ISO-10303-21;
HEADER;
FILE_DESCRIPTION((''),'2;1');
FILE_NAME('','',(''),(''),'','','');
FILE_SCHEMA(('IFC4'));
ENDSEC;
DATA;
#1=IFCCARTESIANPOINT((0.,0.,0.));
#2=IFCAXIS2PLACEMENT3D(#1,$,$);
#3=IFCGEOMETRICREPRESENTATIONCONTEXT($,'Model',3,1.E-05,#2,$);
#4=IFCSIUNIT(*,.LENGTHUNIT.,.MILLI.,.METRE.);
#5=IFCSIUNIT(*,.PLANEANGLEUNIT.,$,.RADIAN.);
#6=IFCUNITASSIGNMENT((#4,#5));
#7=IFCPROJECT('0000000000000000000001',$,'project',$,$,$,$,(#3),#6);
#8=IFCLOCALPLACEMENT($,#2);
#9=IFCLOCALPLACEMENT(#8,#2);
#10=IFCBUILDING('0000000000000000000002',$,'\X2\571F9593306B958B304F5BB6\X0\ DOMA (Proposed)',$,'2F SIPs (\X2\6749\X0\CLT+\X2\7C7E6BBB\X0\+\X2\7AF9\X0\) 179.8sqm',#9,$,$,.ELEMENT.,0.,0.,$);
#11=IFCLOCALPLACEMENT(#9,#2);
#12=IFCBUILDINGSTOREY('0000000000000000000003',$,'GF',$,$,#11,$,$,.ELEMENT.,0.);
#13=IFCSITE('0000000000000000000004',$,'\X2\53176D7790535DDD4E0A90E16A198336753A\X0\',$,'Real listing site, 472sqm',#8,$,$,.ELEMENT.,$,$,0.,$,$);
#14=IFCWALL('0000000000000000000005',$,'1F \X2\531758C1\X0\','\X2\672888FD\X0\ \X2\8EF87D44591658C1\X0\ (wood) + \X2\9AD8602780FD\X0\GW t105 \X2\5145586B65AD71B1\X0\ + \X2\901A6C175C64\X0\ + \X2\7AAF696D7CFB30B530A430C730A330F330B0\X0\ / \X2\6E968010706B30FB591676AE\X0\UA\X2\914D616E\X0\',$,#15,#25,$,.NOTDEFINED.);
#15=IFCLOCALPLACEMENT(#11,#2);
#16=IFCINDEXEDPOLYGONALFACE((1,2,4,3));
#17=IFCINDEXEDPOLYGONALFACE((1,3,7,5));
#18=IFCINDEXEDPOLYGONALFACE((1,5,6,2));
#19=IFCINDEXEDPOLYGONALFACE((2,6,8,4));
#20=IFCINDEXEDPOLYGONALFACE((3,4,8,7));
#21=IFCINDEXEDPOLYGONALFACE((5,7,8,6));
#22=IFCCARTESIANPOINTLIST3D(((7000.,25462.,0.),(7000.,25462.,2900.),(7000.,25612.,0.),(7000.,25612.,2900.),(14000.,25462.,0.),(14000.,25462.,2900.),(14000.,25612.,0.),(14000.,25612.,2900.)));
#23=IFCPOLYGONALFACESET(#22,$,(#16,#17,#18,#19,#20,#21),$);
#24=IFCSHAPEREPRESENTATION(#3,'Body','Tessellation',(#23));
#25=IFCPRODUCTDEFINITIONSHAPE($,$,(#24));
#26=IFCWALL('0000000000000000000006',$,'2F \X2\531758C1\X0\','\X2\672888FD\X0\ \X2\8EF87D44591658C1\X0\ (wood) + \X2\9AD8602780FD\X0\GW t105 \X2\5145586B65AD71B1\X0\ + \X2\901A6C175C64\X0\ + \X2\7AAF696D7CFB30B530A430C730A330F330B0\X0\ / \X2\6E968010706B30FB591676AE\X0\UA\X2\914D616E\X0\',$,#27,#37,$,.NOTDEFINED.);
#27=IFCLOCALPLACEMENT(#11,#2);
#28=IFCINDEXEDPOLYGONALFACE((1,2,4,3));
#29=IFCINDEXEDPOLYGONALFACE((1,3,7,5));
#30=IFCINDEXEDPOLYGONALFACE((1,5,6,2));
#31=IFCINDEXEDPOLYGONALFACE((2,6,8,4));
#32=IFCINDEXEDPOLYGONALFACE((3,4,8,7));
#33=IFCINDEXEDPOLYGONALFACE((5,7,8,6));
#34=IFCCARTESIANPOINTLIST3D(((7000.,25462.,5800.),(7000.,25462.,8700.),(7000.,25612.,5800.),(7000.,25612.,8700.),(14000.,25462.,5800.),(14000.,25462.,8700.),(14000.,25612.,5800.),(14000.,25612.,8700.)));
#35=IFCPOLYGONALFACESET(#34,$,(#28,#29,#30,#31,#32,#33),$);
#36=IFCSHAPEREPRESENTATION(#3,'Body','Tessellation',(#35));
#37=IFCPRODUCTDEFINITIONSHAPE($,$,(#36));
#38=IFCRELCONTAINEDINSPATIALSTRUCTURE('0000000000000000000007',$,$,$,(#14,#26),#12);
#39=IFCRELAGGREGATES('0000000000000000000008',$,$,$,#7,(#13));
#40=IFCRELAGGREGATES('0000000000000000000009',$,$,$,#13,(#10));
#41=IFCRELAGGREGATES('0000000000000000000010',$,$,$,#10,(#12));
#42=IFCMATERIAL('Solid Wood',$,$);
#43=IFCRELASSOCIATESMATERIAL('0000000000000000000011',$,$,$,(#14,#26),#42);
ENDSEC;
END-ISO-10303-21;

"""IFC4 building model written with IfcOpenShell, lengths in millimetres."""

from ifc_helpers import new_model, si_unit, frame, frame_2d, origin, place, context, project, spatial, rectangle, extrude, material, element, save


model = new_model("IFC4")

# Units and contexts
model_context = context("Model", 3, precision=1e-05, world=origin())
ifc_project = project(units=[si_unit("LENGTHUNIT", "METRE", prefix="MILLI"), si_unit("PLANEANGLEUNIT", "RADIAN")], contexts=[model_context])

# Site, building, storey
site_placement = place(None, origin())
site = spatial("IfcSite", under=ifc_project, at=site_placement, Name="北海道川上郡標茶町", ObjectType="Real listing site, 472sqm", CompositionType="ELEMENT", RefElevation=0.0)
building_placement = place(site_placement, origin())
building = spatial("IfcBuilding", under=site, at=building_placement, Name="土間に開く家 DOMA (Proposed)", ObjectType="2F SIPs (杉CLT+籾殻+竹) 179.8sqm", CompositionType="ELEMENT", ElevationOfRefHeight=0.0, ElevationOfTerrain=0.0)
storey_placement = place(building_placement, origin())
storey = spatial("IfcBuildingStorey", under=building, at=storey_placement, Name="GF", CompositionType="ELEMENT", Elevation=0.0)

# Shared definitions
ifc_material_1 = material(Name="Solid Wood")

# Wall
wall_1_placement = place(storey_placement, frame((3500.0, 12731.0, 0.0)))
element("IfcWall", 1, at=wall_1_placement, inside=storey, material=ifc_material_1, Name="1F 北壁", Description="木製 軸組外壁 (wood) + 高性能GW t105 充填断熱 + 通気層 + 窯業系サイディング / 準耐火・外皮UA配慮", PredefinedType="NOTDEFINED", context=model_context, shape_type="SweptSolid", body=[
    extrude(rectangle(XDim=7000.0, YDim=150.0, at=frame_2d((3500.0, 75.0))), frame((3500.0, 12731.0, 0.0)), (0.0, 0.0, 1.0), 2900.0),
])

# Wall
wall_2_placement = place(storey_placement, frame((3500.0, 12731.0, 2900.0)))
element("IfcWall", 2, at=wall_2_placement, inside=storey, material=ifc_material_1, Name="2F 北壁", Description="木製 軸組外壁 (wood) + 高性能GW t105 充填断熱 + 通気層 + 窯業系サイディング / 準耐火・外皮UA配慮", PredefinedType="NOTDEFINED", context=model_context, shape_type="SweptSolid", body=[
    extrude(rectangle(XDim=7000.0, YDim=150.0, at=frame_2d((3500.0, 75.0))), frame((3500.0, 12731.0, 2900.0)), (0.0, 0.0, 1.0), 2900.0),
])

save(model, "model.ifc")
